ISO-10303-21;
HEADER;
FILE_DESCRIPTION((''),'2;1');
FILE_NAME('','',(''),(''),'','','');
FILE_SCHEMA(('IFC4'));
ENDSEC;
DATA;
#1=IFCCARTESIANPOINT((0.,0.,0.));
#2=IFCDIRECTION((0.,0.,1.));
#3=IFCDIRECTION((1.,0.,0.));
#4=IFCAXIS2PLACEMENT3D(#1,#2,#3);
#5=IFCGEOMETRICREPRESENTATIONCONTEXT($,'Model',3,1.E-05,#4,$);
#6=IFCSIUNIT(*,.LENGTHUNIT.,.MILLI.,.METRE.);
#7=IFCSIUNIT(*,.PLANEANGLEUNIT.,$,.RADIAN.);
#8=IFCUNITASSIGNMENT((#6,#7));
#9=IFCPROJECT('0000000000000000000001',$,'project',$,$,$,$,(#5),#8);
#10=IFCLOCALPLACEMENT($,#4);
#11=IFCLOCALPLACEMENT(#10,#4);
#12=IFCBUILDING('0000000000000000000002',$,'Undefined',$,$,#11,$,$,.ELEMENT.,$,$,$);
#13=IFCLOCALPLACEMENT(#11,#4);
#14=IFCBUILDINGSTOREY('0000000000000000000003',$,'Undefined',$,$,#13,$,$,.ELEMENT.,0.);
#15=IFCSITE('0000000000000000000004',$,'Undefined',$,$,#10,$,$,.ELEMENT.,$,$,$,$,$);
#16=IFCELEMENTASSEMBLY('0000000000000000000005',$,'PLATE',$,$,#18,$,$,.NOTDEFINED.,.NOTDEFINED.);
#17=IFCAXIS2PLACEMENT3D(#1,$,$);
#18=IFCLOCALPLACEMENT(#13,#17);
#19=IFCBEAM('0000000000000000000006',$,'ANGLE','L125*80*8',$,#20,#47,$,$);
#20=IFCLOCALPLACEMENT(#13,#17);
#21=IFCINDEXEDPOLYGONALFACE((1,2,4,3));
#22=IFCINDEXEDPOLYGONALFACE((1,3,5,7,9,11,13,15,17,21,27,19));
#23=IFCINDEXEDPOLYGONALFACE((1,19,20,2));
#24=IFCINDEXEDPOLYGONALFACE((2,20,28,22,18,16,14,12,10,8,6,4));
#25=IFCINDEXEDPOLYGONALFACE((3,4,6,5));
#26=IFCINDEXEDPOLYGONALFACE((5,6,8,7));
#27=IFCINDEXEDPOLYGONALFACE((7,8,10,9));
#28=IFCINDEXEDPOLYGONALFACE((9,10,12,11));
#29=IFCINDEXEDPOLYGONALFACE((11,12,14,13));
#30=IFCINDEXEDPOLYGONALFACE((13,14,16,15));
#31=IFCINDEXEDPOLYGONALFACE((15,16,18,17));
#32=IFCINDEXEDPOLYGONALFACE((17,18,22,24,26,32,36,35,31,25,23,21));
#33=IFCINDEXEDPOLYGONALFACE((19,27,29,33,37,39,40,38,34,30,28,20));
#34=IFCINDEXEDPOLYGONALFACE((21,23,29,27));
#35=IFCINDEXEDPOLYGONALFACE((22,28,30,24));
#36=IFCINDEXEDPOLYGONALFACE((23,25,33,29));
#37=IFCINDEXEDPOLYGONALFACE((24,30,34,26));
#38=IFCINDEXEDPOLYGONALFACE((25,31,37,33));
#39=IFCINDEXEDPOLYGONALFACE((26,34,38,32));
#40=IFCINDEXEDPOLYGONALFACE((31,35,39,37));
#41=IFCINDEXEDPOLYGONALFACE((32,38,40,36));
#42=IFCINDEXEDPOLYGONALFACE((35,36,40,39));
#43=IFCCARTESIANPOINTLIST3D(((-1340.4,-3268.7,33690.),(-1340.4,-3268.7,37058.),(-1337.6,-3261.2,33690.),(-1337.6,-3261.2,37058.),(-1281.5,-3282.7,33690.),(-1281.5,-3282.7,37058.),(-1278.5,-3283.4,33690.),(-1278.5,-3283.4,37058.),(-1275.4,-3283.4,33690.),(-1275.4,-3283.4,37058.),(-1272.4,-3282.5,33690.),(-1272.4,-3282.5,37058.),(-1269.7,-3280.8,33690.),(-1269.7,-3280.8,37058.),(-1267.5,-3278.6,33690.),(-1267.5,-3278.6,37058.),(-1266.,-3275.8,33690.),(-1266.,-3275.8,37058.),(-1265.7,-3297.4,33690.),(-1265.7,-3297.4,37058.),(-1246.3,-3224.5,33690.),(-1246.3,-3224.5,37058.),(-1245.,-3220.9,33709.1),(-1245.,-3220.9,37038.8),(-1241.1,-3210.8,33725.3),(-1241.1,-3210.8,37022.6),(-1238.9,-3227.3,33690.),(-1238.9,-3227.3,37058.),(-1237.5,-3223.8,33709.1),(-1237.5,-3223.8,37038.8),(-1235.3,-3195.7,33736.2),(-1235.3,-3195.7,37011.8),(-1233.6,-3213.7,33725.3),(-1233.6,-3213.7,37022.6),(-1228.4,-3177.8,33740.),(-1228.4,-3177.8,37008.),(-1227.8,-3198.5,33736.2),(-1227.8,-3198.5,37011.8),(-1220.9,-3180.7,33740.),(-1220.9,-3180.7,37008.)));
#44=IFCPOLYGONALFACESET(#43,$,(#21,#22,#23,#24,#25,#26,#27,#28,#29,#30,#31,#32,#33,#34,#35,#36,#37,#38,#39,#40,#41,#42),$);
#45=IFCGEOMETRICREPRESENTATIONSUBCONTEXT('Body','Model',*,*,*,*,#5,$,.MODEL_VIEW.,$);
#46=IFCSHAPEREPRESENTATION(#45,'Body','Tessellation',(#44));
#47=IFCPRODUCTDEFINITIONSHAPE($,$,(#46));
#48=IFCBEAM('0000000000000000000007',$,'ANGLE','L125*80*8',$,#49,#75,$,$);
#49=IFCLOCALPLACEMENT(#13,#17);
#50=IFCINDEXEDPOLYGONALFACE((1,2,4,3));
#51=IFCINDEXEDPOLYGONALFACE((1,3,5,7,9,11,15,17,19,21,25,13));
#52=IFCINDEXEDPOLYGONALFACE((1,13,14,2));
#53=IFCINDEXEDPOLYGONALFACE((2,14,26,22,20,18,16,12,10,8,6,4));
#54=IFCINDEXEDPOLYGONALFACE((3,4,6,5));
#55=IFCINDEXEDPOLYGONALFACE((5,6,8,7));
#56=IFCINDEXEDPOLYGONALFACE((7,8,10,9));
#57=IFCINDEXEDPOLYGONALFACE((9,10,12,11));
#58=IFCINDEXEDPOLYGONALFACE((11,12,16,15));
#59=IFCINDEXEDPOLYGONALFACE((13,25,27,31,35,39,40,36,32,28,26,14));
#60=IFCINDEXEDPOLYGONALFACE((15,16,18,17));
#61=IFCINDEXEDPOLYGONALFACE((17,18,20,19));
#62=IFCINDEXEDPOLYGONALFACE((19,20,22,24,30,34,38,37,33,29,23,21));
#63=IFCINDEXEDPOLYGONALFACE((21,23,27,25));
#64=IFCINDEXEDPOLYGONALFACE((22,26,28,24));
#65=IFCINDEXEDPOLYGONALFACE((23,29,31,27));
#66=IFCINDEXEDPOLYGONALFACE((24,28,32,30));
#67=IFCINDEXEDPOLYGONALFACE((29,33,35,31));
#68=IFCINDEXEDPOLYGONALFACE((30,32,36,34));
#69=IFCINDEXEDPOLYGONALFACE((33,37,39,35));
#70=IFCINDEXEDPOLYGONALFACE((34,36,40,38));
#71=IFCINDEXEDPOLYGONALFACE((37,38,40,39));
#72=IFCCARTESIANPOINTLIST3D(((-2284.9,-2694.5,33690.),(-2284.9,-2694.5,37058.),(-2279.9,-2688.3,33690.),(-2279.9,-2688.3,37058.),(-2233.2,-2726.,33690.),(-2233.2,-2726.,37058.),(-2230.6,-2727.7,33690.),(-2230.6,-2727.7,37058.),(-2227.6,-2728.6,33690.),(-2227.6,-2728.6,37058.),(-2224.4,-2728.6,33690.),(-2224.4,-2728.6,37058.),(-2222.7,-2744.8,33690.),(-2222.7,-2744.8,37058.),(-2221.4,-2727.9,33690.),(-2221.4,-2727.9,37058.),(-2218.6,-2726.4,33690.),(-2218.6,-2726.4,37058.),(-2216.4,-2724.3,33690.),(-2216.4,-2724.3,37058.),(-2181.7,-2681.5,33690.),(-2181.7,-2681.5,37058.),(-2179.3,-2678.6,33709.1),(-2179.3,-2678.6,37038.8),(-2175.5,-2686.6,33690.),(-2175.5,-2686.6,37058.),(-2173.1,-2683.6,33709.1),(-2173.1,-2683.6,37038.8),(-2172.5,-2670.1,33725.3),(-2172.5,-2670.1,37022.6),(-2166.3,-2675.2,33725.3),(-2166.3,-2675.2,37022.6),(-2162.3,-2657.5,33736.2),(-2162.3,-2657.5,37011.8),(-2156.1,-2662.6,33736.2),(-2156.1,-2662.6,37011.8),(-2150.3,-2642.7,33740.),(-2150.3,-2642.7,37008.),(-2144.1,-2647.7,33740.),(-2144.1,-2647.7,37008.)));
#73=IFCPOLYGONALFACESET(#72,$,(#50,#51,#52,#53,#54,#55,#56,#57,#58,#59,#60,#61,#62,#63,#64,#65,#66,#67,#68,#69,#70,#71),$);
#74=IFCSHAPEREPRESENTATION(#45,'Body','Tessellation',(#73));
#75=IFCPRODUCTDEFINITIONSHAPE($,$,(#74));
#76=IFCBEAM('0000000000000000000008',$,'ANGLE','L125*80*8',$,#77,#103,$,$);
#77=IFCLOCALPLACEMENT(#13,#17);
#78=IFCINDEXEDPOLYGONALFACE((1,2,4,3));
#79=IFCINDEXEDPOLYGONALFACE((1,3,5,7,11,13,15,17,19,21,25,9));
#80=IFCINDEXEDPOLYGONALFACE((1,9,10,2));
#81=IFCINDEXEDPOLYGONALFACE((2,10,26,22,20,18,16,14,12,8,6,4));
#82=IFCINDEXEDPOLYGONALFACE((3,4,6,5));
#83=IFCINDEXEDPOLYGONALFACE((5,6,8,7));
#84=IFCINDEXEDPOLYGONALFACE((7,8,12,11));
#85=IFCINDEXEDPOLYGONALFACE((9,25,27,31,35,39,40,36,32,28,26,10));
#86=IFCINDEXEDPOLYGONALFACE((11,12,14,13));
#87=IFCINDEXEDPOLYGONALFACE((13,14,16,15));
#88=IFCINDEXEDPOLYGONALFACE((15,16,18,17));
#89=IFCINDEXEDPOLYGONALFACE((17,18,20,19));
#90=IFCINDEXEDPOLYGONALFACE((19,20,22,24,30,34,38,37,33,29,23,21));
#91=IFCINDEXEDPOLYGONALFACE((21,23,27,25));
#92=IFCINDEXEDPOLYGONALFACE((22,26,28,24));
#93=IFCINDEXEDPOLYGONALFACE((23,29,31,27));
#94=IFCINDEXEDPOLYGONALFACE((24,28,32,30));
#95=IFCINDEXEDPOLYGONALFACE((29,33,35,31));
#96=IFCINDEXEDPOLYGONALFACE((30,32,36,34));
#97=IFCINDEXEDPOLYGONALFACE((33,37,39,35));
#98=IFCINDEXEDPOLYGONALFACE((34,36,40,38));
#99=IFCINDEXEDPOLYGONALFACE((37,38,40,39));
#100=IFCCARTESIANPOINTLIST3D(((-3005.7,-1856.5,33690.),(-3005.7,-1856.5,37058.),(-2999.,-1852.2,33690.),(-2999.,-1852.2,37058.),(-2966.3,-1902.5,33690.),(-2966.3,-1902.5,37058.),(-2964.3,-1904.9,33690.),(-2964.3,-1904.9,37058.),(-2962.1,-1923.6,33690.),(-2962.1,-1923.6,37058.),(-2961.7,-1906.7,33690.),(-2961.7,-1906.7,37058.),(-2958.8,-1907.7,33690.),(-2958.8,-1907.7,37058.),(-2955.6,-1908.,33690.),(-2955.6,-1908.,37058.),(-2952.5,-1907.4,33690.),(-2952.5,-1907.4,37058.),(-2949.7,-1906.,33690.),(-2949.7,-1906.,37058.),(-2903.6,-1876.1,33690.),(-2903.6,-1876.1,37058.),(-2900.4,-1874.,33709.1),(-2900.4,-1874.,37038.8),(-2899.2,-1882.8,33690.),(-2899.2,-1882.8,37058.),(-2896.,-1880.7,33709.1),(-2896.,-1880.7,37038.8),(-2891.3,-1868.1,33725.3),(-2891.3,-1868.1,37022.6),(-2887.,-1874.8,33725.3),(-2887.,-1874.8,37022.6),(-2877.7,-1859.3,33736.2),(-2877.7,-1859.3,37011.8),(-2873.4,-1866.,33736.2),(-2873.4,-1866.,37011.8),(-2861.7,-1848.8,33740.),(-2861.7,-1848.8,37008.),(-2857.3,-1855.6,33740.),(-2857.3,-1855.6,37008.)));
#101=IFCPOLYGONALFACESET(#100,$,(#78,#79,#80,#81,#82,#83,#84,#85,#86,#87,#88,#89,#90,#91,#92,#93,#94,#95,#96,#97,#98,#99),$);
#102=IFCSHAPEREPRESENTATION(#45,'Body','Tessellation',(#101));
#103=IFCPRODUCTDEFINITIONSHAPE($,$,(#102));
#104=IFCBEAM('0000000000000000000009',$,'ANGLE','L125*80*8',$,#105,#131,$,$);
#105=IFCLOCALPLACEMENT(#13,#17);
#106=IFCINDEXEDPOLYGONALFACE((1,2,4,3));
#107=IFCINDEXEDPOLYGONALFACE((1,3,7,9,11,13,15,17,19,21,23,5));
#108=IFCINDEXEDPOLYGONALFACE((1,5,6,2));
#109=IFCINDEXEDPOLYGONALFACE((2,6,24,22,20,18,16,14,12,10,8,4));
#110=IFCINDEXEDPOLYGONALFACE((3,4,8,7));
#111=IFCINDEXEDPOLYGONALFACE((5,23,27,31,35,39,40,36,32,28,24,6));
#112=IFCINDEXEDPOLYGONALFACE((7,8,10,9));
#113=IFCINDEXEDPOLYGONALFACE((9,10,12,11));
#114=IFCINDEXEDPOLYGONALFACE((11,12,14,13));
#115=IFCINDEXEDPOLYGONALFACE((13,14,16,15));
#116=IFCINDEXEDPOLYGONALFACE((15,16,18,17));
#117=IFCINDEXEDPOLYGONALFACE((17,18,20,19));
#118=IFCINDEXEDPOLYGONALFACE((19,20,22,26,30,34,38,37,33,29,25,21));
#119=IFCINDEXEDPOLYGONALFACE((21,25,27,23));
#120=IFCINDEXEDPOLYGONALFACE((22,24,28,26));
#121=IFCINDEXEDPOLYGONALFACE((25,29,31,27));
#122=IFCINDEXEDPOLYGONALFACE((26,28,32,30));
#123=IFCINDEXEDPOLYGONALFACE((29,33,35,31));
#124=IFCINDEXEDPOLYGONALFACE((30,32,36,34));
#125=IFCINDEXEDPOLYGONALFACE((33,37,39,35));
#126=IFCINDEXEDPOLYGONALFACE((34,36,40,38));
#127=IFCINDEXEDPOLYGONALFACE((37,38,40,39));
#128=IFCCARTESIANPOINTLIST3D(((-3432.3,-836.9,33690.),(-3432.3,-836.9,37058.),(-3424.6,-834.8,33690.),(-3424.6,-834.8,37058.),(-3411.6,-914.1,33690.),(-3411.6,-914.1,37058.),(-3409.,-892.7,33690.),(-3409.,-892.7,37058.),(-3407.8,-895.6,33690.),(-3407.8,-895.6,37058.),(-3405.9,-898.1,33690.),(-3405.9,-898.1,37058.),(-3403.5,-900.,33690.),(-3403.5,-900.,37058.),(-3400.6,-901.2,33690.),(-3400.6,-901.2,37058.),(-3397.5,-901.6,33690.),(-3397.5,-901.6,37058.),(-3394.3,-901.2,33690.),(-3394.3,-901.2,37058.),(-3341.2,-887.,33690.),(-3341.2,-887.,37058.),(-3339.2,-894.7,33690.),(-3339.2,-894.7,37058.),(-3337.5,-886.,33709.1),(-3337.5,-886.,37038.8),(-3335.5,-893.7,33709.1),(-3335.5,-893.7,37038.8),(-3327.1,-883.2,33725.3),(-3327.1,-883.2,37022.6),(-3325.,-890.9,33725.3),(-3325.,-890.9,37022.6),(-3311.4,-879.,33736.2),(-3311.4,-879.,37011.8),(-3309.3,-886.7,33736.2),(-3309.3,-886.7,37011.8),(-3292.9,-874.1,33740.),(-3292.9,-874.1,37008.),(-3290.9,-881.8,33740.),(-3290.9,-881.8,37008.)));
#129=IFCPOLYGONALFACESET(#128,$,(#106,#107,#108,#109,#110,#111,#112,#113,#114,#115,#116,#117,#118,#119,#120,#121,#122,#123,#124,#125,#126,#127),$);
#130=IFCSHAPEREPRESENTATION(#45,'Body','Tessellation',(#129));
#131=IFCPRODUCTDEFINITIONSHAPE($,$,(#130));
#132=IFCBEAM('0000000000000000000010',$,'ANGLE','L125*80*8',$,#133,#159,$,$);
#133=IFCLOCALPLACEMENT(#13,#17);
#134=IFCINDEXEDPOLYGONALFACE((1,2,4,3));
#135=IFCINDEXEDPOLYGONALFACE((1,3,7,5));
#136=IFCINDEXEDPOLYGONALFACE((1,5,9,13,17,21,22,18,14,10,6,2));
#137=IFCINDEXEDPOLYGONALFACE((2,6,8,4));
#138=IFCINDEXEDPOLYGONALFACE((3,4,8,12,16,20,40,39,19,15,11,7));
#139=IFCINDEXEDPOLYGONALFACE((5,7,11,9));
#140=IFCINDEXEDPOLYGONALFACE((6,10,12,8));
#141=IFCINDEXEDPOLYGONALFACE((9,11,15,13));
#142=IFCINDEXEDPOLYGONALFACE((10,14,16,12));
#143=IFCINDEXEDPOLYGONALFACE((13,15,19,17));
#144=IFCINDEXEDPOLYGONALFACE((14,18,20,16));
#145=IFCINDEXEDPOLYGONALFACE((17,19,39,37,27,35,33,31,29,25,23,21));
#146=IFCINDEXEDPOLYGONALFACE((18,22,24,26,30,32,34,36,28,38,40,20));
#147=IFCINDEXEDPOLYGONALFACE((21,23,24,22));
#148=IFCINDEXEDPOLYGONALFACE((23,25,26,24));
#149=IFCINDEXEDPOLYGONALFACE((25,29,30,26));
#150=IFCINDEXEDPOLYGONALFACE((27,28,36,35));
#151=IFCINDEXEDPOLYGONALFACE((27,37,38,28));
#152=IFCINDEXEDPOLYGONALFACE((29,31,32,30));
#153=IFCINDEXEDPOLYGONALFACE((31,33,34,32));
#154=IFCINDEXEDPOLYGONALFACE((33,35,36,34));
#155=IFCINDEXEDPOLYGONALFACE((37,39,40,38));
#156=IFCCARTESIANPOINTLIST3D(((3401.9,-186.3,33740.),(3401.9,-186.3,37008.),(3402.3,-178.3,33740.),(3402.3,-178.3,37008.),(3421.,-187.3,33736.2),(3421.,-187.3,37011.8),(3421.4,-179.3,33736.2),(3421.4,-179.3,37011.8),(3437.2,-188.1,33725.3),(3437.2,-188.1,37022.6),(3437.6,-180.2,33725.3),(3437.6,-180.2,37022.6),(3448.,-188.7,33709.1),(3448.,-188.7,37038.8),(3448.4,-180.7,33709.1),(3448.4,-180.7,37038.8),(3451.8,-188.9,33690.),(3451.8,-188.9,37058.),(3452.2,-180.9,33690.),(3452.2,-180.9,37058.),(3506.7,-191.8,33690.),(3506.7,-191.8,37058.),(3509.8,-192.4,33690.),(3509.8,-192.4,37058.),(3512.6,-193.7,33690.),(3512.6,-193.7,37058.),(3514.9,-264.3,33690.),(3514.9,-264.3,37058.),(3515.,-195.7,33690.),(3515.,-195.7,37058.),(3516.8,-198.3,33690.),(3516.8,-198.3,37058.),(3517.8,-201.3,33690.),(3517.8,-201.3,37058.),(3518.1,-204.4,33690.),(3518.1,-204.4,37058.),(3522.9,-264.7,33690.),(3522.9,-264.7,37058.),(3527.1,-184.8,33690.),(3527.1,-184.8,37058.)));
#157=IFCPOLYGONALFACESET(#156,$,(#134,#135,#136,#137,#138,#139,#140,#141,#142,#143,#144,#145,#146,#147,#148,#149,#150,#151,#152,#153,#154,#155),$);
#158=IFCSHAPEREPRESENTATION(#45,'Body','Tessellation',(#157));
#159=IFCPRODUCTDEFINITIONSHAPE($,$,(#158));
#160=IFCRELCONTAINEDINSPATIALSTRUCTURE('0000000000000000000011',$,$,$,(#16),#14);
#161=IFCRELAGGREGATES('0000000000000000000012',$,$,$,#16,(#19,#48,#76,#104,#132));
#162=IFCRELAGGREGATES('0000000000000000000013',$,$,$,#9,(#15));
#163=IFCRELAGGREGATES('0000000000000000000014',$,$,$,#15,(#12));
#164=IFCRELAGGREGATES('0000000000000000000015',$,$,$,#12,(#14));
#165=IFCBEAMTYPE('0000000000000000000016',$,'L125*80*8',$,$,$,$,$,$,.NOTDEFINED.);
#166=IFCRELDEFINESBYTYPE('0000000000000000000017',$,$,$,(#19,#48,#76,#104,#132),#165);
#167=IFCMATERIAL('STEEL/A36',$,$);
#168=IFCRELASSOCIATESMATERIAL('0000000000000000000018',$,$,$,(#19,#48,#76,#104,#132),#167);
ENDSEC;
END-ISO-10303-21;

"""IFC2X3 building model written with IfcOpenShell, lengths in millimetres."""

from ifc_helpers import new_model, si_unit, frame, origin_with_axes, origin_2d_with_axis, place, context, subcontext, project, spatial, polyline, l_section, outline, extrude, boolean, material, type_object, element, aggregate, save


model = new_model("IFC2X3")

# Units and contexts
model_context = context("Model", 3, precision=1e-05, world=origin_with_axes())
body_context = subcontext(model_context, "Body", "Model", "MODEL_VIEW")
ifc_project = project(units=[si_unit("LENGTHUNIT", "METRE", prefix="MILLI"), si_unit("PLANEANGLEUNIT", "RADIAN")], contexts=[model_context])

# Site, building, storey
site_placement = place(None, origin_with_axes())
site = spatial("IfcSite", under=ifc_project, at=site_placement, Name="Undefined", CompositionType="ELEMENT")
building_placement = place(site_placement, origin_with_axes())
building = spatial("IfcBuilding", under=site, at=building_placement, Name="Undefined", CompositionType="ELEMENT")
storey_placement = place(building_placement, origin_with_axes())
storey = spatial("IfcBuildingStorey", under=building, at=storey_placement, Name="Undefined", CompositionType="ELEMENT", Elevation=0.0)

# Element assembly, beams
assembly_1_placement = place(storey_placement, origin_with_axes())
assembly_1 = element("IfcElementAssembly", 1, at=assembly_1_placement, inside=storey, Name="PLATE", AssemblyPlace="NOTDEFINED", PredefinedType="NOTDEFINED")
ifc_material_1 = material(Name="STEEL/A36")
beam_type = type_object("IfcBeamType", Name="L125*80*8", PredefinedType="NOTDEFINED")
beam_1_placement = place(assembly_1_placement, frame((-1280.7, -3224.7, 33690.0), z_axis=(0.358368, 0.93358, 0.0), x_axis=(0.0, 0.0, 1.0)))
beam_1 = element("IfcBeam", 2, at=beam_1_placement, type_object=beam_type, material=ifc_material_1, Name="ANGLE", Description="L125*80*8", context=body_context, shape_type="CSG", body=[
    boolean("DIFFERENCE", boolean("DIFFERENCE", extrude(l_section(Depth=125.0, Width=80.0, Thickness=8.0, FilletRadius=12.0, at=origin_2d_with_axis()), frame((3368.0, 0.0, 0.0), z_axis=(-1.0, 0.0, 0.0), x_axis=(0.0, -1.0, 0.0)), (0.0, 0.0, 1.0), 3368.0), extrude(outline(polyline([(0.0, 0.0), (50.0, 0.0), (50.0, 0.0), (46.2, 19.1), (35.4, 35.4), (19.1, 46.2), (0.0, 50.0), (0.0, 50.0), (0.0, 0.0)])), frame((0.0, -38.0, 62.5), z_axis=(0.0, 1.0, 0.0), x_axis=(1.0, 0.0, 0.0)), (0.0, 0.0, 1.0), 81.0)), extrude(outline(polyline([(0.0, 0.0), (50.0, 0.0), (50.0, 0.0), (46.2, 19.1), (35.4, 35.4), (19.1, 46.2), (0.0, 50.0), (0.0, 50.0), (0.0, 0.0)])), frame((3368.0, -38.0, 62.5), z_axis=(0.0, 1.0, 0.0), x_axis=(-0.000152, -0.000001, -1.0)), (0.0, 0.0, 1.0), 81.0)),
])
beam_2_placement = place(assembly_1_placement, frame((-2214.5, -2671.1, 33690.0), z_axis=(0.62932, 0.777146, 0.0), x_axis=(0.0, 0.0, 1.0)))
beam_2 = element("IfcBeam", 3, at=beam_2_placement, type_object=beam_type, material=ifc_material_1, Name="ANGLE", Description="L125*80*8", context=body_context, shape_type="CSG", body=[
    boolean("DIFFERENCE", boolean("DIFFERENCE", extrude(l_section(Depth=125.0, Width=80.0, Thickness=8.0, FilletRadius=12.0, at=origin_2d_with_axis()), frame((3368.0, 0.0, 0.0), z_axis=(-1.0, 0.0, 0.0), x_axis=(0.0, -1.0, 0.0)), (0.0, 0.0, 1.0), 3368.0), extrude(outline(polyline([(0.0, 0.0), (50.0, 0.0), (50.0, 0.0), (46.2, 19.1), (35.4, 35.4), (19.1, 46.2), (0.0, 50.0), (0.0, 50.0), (0.0, 0.0)])), frame((0.0, -38.0, 62.5), z_axis=(0.0, 1.0, 0.0), x_axis=(1.0, 0.0, 0.0)), (0.0, 0.0, 1.0), 81.0)), extrude(outline(polyline([(0.0, 0.0), (50.0, 0.0), (50.0, 0.0), (46.2, 19.1), (35.4, 35.4), (19.1, 46.2), (0.0, 50.0), (0.0, 50.0), (0.0, 0.0)])), frame((3368.0, -38.0, 62.5), z_axis=(0.0, 1.0, 0.0), x_axis=(-0.000152, -0.000001, -1.0)), (0.0, 0.0, 1.0), 81.0)),
])
beam_3_placement = place(assembly_1_placement, frame((-2931.5, -1856.0, 33690.0), z_axis=(0.838671, 0.544639, 0.0), x_axis=(0.0, 0.0, 1.0)))
beam_3 = element("IfcBeam", 4, at=beam_3_placement, type_object=beam_type, material=ifc_material_1, Name="ANGLE", Description="L125*80*8", context=body_context, shape_type="CSG", body=[
    boolean("DIFFERENCE", boolean("DIFFERENCE", extrude(l_section(Depth=125.0, Width=80.0, Thickness=8.0, FilletRadius=12.0, at=origin_2d_with_axis()), frame((3368.0, 0.0, 0.0), z_axis=(-1.0, 0.0, 0.0), x_axis=(0.0, -1.0, 0.0)), (0.0, 0.0, 1.0), 3368.0), extrude(outline(polyline([(0.0, 0.0), (50.0, 0.0), (50.0, 0.0), (46.2, 19.1), (35.4, 35.4), (19.1, 46.2), (0.0, 50.0), (0.0, 50.0), (0.0, 0.0)])), frame((0.0, -38.0, 62.5), z_axis=(0.0, 1.0, 0.0), x_axis=(1.0, 0.0, 0.0)), (0.0, 0.0, 1.0), 81.0)), extrude(outline(polyline([(0.0, 0.0), (50.0, 0.0), (50.0, 0.0), (46.2, 19.1), (35.4, 35.4), (19.1, 46.2), (0.0, 50.0), (0.0, 50.0), (0.0, 0.0)])), frame((3368.0, -38.0, 62.5), z_axis=(0.0, 1.0, 0.0), x_axis=(-0.000152, -0.000001, -1.0)), (0.0, 0.0, 1.0), 81.0)),
])
beam_4_placement = place(assembly_1_placement, frame((-3361.6, -859.3, 33690.0), z_axis=(0.965926, 0.258819, 0.0), x_axis=(0.0, 0.0, 1.0)))
beam_4 = element("IfcBeam", 5, at=beam_4_placement, type_object=beam_type, material=ifc_material_1, Name="ANGLE", Description="L125*80*8", context=body_context, shape_type="CSG", body=[
    boolean("DIFFERENCE", boolean("DIFFERENCE", extrude(l_section(Depth=125.0, Width=80.0, Thickness=8.0, FilletRadius=12.0, at=origin_2d_with_axis()), frame((3368.0, 0.0, 0.0), z_axis=(-1.0, 0.0, 0.0), x_axis=(0.0, -1.0, 0.0)), (0.0, 0.0, 1.0), 3368.0), extrude(outline(polyline([(0.0, 0.0), (50.0, 0.0), (50.0, 0.0), (46.2, 19.1), (35.4, 35.4), (19.1, 46.2), (0.0, 50.0), (0.0, 50.0), (0.0, 0.0)])), frame((0.0, -38.0, 62.5), z_axis=(0.0, 1.0, 0.0), x_axis=(1.0, 0.0, 0.0)), (0.0, 0.0, 1.0), 81.0)), extrude(outline(polyline([(0.0, 0.0), (50.0, 0.0), (50.0, 0.0), (46.2, 19.1), (35.4, 35.4), (19.1, 46.2), (0.0, 50.0), (0.0, 50.0), (0.0, 0.0)])), frame((3368.0, -38.0, 62.5), z_axis=(0.0, 1.0, 0.0), x_axis=(-0.000152, -0.000001, -1.0)), (0.0, 0.0, 1.0), 81.0)),
])
beam_5_placement = place(assembly_1_placement, frame((3462.6, -221.5, 33690.0), z_axis=(-0.99863, 0.052336, 0.0), x_axis=(0.0, 0.0, 1.0)))
beam_5 = element("IfcBeam", 6, at=beam_5_placement, type_object=beam_type, material=ifc_material_1, Name="ANGLE", Description="L125*80*8", context=body_context, shape_type="CSG", body=[
    boolean("DIFFERENCE", boolean("DIFFERENCE", extrude(l_section(Depth=125.0, Width=80.0, Thickness=8.0, FilletRadius=12.0, at=origin_2d_with_axis()), frame((3368.0, 0.0, 0.0), z_axis=(-1.0, 0.0, 0.0), x_axis=(0.0, -1.0, 0.0)), (0.0, 0.0, 1.0), 3368.0), extrude(outline(polyline([(0.0, 0.0), (50.0, 0.0), (50.0, 0.0), (46.2, 19.1), (35.4, 35.4), (19.1, 46.2), (0.0, 50.0), (0.0, 50.0), (0.0, 0.0)])), frame((0.0, -38.0, 62.5), z_axis=(0.0, 1.0, 0.0), x_axis=(1.0, 0.0, 0.0)), (0.0, 0.0, 1.0), 81.0)), extrude(outline(polyline([(0.0, 0.0), (50.0, 0.0), (50.0, 0.0), (46.2, 19.1), (35.4, 35.4), (19.1, 46.2), (0.0, 50.0), (0.0, 50.0), (0.0, 0.0)])), frame((3368.0, -38.0, 62.5), z_axis=(0.0, 1.0, 0.0), x_axis=(-0.000152, -0.000001, -1.0)), (0.0, 0.0, 1.0), 81.0)),
])
aggregate(assembly_1, [beam_1, beam_2, beam_3, beam_4, beam_5])

save(model, "model.ifc")
